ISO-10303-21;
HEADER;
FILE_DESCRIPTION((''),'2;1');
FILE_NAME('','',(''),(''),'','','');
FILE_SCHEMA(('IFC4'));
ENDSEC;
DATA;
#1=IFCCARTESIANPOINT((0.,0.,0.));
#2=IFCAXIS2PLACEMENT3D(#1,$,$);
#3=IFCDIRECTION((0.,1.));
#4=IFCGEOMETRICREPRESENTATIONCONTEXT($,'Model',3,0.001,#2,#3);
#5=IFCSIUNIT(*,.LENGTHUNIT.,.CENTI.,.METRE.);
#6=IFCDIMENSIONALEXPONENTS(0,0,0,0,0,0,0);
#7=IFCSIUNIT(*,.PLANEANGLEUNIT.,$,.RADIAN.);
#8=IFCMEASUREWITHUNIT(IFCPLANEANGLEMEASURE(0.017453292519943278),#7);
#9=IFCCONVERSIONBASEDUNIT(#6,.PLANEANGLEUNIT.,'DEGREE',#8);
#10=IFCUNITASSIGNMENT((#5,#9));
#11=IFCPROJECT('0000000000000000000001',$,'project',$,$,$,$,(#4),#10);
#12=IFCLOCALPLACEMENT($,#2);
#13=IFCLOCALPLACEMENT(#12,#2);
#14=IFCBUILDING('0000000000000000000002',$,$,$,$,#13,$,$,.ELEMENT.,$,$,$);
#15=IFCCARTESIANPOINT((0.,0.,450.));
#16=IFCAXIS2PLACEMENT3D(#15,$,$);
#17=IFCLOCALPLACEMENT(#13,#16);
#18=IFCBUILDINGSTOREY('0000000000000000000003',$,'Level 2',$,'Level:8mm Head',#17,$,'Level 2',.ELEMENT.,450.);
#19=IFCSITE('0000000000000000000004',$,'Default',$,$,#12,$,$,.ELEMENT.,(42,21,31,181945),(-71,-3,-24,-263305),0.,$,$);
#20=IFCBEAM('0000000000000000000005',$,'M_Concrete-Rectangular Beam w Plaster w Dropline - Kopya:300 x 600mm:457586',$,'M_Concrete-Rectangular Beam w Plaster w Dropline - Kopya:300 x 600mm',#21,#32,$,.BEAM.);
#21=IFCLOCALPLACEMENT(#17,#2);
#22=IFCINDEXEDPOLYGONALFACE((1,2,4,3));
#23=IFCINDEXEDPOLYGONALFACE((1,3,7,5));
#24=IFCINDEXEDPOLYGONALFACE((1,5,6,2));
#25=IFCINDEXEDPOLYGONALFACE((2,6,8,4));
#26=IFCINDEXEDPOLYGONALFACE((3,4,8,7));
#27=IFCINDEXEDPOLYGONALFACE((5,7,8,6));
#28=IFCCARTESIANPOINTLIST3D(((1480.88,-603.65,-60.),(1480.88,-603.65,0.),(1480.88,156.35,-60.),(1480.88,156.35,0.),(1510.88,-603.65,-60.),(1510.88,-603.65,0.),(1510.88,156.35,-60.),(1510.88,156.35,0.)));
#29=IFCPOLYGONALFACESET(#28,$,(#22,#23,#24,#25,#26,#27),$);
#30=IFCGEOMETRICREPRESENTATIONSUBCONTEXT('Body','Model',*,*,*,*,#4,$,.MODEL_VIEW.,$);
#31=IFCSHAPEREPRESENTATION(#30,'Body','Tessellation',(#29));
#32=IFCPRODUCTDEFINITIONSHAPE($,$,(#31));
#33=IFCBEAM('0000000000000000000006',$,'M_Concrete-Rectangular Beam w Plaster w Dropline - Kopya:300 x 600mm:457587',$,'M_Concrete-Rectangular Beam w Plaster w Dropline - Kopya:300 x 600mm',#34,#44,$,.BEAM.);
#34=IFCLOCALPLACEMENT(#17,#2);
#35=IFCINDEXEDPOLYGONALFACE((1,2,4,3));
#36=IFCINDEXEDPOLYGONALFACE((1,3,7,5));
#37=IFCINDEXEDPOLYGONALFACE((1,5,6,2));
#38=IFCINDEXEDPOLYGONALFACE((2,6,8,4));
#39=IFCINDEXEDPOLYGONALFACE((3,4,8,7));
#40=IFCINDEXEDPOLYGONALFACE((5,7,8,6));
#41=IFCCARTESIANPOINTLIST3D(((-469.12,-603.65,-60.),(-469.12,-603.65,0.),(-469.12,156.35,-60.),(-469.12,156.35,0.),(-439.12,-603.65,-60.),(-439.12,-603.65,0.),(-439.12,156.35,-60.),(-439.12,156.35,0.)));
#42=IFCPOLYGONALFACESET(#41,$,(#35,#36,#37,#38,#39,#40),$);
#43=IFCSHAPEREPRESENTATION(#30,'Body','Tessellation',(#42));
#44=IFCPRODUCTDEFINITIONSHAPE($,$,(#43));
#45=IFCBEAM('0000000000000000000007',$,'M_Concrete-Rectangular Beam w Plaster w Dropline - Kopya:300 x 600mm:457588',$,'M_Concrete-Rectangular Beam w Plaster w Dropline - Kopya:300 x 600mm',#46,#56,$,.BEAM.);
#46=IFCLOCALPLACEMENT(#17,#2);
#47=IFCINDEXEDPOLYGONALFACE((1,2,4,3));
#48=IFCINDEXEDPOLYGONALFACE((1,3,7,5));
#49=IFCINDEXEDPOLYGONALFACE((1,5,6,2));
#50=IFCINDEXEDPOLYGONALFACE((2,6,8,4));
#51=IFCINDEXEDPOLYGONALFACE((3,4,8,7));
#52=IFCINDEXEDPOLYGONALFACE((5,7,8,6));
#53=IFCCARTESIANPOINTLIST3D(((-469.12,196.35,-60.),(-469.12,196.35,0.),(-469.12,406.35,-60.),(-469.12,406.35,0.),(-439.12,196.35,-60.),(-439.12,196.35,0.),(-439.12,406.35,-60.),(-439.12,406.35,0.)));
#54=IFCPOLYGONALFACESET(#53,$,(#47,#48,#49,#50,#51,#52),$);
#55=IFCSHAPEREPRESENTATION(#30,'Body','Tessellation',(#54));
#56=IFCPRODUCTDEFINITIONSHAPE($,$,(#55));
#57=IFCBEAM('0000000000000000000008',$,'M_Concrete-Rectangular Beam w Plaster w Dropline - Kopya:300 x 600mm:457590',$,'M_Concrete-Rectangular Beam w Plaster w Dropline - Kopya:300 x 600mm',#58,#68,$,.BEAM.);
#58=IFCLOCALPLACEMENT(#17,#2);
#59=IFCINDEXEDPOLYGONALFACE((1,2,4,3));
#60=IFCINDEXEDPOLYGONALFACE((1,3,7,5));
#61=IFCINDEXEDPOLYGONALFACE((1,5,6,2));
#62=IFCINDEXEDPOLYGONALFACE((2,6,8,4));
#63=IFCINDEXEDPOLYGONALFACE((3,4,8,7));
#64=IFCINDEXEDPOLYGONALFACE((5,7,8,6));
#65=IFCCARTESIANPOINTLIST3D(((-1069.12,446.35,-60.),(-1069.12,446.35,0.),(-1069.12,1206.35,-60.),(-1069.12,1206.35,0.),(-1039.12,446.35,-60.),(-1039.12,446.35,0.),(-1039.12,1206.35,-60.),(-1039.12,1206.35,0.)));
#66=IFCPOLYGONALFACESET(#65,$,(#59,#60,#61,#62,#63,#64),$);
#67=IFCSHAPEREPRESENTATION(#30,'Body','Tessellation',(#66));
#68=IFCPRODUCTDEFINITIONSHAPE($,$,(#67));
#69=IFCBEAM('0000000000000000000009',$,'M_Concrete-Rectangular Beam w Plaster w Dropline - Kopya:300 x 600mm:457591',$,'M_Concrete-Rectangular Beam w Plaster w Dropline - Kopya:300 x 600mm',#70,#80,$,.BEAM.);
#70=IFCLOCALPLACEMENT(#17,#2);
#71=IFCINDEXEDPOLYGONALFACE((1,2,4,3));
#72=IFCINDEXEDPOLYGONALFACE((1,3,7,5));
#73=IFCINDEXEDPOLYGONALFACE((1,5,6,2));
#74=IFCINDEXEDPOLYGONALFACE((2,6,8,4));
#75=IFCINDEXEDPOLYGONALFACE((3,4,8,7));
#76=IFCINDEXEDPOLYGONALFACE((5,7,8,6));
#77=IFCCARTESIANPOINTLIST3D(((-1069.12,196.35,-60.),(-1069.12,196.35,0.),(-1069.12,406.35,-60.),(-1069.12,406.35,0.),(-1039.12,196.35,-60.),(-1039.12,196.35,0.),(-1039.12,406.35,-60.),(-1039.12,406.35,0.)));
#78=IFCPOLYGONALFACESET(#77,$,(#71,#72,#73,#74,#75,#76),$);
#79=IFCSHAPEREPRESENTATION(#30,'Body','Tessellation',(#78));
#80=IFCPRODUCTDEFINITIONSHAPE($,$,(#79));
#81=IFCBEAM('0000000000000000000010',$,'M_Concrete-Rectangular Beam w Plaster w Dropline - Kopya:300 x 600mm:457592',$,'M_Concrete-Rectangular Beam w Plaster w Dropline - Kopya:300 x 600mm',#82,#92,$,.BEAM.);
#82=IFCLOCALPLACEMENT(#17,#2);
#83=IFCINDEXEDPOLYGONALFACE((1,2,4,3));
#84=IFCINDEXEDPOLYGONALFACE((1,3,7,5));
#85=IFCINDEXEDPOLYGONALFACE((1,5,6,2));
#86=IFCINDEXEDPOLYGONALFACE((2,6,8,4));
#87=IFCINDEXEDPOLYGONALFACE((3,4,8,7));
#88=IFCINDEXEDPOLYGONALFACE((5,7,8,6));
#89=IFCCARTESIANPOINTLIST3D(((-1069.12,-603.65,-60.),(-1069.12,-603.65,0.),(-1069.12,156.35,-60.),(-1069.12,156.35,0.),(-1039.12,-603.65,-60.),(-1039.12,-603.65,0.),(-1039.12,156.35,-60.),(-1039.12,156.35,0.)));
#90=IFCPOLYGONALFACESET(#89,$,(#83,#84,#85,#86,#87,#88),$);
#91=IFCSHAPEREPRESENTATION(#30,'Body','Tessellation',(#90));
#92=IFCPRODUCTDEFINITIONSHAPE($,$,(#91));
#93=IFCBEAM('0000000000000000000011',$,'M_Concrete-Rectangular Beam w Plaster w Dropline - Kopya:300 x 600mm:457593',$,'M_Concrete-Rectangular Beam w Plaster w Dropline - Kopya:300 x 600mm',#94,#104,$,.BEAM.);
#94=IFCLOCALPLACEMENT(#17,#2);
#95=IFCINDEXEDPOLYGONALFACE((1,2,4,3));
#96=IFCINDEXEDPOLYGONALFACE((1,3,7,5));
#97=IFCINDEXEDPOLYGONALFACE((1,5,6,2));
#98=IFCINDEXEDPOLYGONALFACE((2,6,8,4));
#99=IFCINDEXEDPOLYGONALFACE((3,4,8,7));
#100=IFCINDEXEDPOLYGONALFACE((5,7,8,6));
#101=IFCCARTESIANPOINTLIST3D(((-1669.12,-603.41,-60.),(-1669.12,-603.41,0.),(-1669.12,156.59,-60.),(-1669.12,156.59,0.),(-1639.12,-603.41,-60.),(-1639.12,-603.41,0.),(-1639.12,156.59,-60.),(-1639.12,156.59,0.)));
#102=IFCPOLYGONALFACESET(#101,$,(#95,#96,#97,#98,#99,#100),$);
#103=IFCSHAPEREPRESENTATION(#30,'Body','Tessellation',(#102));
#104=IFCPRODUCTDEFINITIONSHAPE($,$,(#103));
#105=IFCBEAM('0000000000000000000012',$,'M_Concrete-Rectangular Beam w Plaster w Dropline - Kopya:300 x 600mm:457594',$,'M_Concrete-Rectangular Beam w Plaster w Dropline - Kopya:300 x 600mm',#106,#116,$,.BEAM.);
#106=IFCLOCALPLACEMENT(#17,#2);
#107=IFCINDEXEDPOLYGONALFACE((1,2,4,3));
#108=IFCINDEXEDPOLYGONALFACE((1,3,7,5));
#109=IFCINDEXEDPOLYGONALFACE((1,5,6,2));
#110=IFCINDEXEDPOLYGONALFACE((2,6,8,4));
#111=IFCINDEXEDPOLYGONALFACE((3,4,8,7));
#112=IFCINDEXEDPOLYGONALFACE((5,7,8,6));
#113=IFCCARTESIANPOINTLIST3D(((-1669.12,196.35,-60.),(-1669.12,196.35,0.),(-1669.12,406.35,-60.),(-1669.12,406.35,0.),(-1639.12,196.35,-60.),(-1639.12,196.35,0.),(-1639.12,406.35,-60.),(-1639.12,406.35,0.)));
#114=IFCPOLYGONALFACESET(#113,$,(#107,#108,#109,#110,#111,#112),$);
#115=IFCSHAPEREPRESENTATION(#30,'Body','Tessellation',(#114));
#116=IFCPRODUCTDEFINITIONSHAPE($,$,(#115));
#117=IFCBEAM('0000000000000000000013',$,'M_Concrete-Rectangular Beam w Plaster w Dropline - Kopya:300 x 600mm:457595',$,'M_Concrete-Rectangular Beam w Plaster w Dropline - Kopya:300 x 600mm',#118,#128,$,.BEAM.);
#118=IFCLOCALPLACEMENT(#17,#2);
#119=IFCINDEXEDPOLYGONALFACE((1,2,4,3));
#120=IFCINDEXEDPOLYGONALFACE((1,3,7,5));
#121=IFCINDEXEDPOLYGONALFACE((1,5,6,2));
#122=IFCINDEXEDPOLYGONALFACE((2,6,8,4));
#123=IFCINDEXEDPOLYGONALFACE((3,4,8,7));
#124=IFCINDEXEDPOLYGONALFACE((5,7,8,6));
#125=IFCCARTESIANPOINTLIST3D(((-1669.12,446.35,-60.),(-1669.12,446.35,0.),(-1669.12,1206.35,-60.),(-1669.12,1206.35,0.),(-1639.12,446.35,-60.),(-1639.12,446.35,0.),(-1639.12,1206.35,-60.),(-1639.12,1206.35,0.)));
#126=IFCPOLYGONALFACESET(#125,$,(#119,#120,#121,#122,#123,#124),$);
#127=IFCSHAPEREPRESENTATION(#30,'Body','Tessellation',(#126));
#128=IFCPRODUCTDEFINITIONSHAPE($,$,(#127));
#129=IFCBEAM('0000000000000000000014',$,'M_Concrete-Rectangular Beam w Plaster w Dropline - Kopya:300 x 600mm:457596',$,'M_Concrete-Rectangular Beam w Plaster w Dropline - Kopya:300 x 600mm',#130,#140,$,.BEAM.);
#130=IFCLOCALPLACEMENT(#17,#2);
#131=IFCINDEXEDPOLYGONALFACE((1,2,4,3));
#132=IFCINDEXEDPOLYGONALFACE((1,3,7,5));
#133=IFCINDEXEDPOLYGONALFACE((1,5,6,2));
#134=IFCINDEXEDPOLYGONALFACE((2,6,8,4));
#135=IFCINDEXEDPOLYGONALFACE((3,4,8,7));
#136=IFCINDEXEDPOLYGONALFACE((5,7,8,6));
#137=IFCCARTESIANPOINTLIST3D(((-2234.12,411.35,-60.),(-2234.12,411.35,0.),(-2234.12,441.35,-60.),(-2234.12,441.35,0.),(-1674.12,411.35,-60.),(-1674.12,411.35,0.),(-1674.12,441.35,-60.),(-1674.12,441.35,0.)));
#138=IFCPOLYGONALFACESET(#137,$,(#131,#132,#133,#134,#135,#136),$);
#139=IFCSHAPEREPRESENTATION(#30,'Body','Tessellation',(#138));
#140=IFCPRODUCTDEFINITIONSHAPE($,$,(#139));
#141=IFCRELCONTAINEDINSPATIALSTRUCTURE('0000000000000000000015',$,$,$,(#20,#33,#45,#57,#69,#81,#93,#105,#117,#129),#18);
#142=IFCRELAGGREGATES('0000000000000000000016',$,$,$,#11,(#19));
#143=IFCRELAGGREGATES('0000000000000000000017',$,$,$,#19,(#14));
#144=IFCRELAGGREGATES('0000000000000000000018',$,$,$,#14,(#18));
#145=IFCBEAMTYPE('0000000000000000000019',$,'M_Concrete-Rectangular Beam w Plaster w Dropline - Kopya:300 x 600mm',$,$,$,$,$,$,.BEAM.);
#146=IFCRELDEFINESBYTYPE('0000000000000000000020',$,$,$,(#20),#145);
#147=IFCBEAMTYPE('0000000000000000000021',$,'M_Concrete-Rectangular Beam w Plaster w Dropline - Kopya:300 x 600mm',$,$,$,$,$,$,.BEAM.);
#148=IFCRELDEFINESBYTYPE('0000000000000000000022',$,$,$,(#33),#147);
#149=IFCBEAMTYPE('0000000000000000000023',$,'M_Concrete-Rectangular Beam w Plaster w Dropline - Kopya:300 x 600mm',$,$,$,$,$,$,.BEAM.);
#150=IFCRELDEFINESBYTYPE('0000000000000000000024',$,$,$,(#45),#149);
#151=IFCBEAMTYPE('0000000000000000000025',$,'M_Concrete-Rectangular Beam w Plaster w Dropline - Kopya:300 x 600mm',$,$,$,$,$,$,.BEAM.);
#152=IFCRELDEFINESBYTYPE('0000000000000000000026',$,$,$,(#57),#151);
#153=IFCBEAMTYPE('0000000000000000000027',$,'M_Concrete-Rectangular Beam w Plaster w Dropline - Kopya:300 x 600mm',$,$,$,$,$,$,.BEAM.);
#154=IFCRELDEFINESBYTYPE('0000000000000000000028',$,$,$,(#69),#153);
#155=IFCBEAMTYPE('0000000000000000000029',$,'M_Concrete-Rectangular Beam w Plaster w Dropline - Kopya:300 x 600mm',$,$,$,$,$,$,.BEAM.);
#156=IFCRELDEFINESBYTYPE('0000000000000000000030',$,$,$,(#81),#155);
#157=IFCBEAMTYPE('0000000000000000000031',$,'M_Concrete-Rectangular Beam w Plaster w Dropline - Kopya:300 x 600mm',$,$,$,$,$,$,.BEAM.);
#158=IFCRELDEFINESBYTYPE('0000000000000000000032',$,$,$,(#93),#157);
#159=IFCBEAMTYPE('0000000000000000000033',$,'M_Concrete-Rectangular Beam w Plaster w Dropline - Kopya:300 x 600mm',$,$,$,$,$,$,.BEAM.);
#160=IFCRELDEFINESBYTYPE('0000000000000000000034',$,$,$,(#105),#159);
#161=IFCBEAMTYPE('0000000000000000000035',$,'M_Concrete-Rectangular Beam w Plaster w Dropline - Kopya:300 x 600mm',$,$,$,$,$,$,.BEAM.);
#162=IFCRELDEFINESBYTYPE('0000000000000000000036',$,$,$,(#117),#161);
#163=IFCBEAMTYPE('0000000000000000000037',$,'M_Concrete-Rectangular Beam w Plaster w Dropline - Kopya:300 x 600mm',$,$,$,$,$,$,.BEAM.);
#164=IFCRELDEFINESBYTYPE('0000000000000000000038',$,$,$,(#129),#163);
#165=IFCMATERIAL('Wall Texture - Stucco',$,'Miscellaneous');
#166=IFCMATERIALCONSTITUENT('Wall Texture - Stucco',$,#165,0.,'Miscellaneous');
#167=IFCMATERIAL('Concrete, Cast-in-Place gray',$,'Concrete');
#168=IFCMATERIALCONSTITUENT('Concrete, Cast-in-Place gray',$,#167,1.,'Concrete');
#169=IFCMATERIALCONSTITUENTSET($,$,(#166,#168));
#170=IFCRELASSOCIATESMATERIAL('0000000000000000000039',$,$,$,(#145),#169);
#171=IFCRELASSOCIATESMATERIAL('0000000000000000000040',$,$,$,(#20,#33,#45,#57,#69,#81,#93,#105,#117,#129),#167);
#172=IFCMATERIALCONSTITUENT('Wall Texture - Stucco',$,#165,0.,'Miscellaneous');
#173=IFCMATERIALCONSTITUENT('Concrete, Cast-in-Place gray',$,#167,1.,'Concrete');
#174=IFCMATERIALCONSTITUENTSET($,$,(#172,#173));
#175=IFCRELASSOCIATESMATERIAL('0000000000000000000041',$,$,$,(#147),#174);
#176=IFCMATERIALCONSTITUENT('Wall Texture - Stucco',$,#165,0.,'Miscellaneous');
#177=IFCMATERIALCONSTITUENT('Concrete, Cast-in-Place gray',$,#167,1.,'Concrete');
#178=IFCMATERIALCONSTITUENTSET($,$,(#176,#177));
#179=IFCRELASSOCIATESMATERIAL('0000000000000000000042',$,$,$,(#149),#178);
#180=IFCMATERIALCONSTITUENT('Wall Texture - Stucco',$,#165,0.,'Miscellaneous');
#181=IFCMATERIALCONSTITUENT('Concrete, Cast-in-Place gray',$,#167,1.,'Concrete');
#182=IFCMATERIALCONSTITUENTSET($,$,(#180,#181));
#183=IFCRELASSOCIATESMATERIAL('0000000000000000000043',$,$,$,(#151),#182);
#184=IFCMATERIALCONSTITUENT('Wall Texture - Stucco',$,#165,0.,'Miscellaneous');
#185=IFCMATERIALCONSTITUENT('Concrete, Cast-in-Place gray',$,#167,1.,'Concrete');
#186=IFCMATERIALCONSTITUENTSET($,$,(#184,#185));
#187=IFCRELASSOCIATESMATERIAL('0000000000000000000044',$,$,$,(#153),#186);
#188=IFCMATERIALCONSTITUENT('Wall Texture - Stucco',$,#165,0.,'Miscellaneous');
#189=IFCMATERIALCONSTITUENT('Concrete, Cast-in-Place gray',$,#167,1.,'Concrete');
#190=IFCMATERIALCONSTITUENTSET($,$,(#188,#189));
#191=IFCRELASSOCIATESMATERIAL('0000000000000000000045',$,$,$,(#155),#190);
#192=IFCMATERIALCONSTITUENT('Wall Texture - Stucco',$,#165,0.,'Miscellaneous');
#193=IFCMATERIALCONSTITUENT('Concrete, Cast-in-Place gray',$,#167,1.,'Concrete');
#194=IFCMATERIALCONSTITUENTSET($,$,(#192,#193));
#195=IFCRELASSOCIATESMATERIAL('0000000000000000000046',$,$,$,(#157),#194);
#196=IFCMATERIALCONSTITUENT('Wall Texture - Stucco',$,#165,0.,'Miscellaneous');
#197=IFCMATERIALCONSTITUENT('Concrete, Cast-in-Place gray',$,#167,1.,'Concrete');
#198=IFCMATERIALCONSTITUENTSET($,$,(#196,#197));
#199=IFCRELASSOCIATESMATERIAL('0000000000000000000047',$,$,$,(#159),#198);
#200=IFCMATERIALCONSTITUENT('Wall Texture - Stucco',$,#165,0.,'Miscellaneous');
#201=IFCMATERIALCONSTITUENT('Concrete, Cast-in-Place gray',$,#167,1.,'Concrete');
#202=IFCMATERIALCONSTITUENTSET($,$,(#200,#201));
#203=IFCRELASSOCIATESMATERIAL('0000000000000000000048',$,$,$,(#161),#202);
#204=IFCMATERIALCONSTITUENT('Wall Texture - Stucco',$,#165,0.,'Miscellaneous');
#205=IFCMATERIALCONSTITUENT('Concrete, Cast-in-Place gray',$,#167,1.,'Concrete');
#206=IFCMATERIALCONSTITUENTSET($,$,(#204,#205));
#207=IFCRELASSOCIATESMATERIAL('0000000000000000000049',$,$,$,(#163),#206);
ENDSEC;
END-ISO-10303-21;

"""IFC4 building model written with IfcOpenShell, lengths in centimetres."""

from ifc_helpers import new_model, entity, si_unit, converted_unit, direction, frame, origin, place, context, subcontext, project, spatial, indexed_curve, outline, extrude, source, transform, mapped, material, constituent, constituent_set, type_object, type_shapes, element, save


model = new_model("IFC4")

# Units and contexts
model_context = context("Model", 3, precision=0.001, world=origin(), true_north=direction((0.0, 1.0)))
body_context = subcontext(model_context, "Body", "Model", "MODEL_VIEW")
ifc_project = project(units=[si_unit("LENGTHUNIT", "METRE", prefix="CENTI"), converted_unit("PLANEANGLEUNIT", "DEGREE", entity("IfcPlaneAngleMeasure", 0.017453292519943278), si_unit("PLANEANGLEUNIT", "RADIAN"), dimensions=[0, 0, 0, 0, 0, 0, 0])], contexts=[model_context])

# Site, building, storey
site_placement = place(None, origin())
site = spatial("IfcSite", under=ifc_project, at=site_placement, Name="Default", CompositionType="ELEMENT", RefLatitude=(42, 21, 31, 181945), RefLongitude=(-71, -3, -24, -263305), RefElevation=0.0)
building_placement = place(site_placement, origin())
building = spatial("IfcBuilding", under=site, at=building_placement, CompositionType="ELEMENT")
storey_placement = place(building_placement, frame((0.0, 0.0, 450.0)))
storey = spatial("IfcBuildingStorey", under=building, at=storey_placement, Name="Level 2", ObjectType="Level:8mm Head", LongName="Level 2", CompositionType="ELEMENT", Elevation=450.0)

# Beams
ifc_material_1 = material(Name="Concrete, Cast-in-Place gray", Category="Concrete")
ifc_material_2 = material(Name="Wall Texture - Stucco", Category="Miscellaneous")
ifc_constituent_1 = constituent(ifc_material_2, Name="Wall Texture - Stucco", Category="Miscellaneous", fraction=0.0)
ifc_constituent_2 = constituent(ifc_material_1, Name="Concrete, Cast-in-Place gray", Category="Concrete", fraction=1.0)
ifc_constituent_set_1 = constituent_set(constituents=[ifc_constituent_1, ifc_constituent_2])
beam_type_1 = type_object("IfcBeamType", Name="M_Concrete-Rectangular Beam w Plaster w Dropline - Kopya:300 x 600mm", PredefinedType="BEAM", material=ifc_constituent_set_1)
shared_shape_1 = source(origin(), body_context, "Body", "SweptSolid", [
    extrude(outline(indexed_curve([(-15.0, -30.0), (15.0, -30.0), (15.0, 30.0), (-15.0, 30.0), (-15.0, -30.0)], self_intersect=False)), frame((1495.88, 156.35, 420.0), z_axis=(0.0, -1.0, 0.0), x_axis=(-1.0, 0.0, 0.0)), (0.0, 0.0, 1.0), 760.0),
])
type_shapes(beam_type_1, [shared_shape_1])
beam_1_placement = place(storey_placement, frame((0.0, 0.0, -450.0)))
element("IfcBeam", 1, at=beam_1_placement, inside=storey, type_object=beam_type_1, material=ifc_material_1, Name="M_Concrete-Rectangular Beam w Plaster w Dropline - Kopya:300 x 600mm:457586", ObjectType="M_Concrete-Rectangular Beam w Plaster w Dropline - Kopya:300 x 600mm", PredefinedType="BEAM", context=body_context, shape_type="MappedRepresentation", body=[
    mapped(shared_shape_1, transform((0.0, 0.0, 0.0), scale=1.0)),
])
ifc_constituent_3 = constituent(ifc_material_2, Name="Wall Texture - Stucco", Category="Miscellaneous", fraction=0.0)
ifc_constituent_4 = constituent(ifc_material_1, Name="Concrete, Cast-in-Place gray", Category="Concrete", fraction=1.0)
ifc_constituent_set_2 = constituent_set(constituents=[ifc_constituent_3, ifc_constituent_4])
beam_type_2 = type_object("IfcBeamType", Name="M_Concrete-Rectangular Beam w Plaster w Dropline - Kopya:300 x 600mm", PredefinedType="BEAM", material=ifc_constituent_set_2)
shared_shape_2 = source(origin(), body_context, "Body", "SweptSolid", [
    extrude(outline(indexed_curve([(-15.0, -30.0), (15.0, -30.0), (15.0, 30.0), (-15.0, 30.0), (-15.0, -30.0)], self_intersect=False)), frame((-454.12, -603.65, 420.0), z_axis=(0.0, 1.0, 0.0), x_axis=(-1.0, 0.0, 0.0)), (0.0, 0.0, 1.0), 760.0),
])
type_shapes(beam_type_2, [shared_shape_2])
beam_2_placement = place(storey_placement, frame((0.0, 0.0, -450.0)))
element("IfcBeam", 2, at=beam_2_placement, inside=storey, type_object=beam_type_2, material=ifc_material_1, Name="M_Concrete-Rectangular Beam w Plaster w Dropline - Kopya:300 x 600mm:457587", ObjectType="M_Concrete-Rectangular Beam w Plaster w Dropline - Kopya:300 x 600mm", PredefinedType="BEAM", context=body_context, shape_type="MappedRepresentation", body=[
    mapped(shared_shape_2, transform((0.0, 0.0, 0.0), scale=1.0)),
])
ifc_constituent_5 = constituent(ifc_material_2, Name="Wall Texture - Stucco", Category="Miscellaneous", fraction=0.0)
ifc_constituent_6 = constituent(ifc_material_1, Name="Concrete, Cast-in-Place gray", Category="Concrete", fraction=1.0)
ifc_constituent_set_3 = constituent_set(constituents=[ifc_constituent_5, ifc_constituent_6])
beam_type_3 = type_object("IfcBeamType", Name="M_Concrete-Rectangular Beam w Plaster w Dropline - Kopya:300 x 600mm", PredefinedType="BEAM", material=ifc_constituent_set_3)
shared_shape_3 = source(origin(), body_context, "Body", "SweptSolid", [
    extrude(outline(indexed_curve([(-15.0, -30.0), (15.0, -30.0), (15.0, 30.0), (-15.0, 30.0), (-15.0, -30.0)], self_intersect=False)), frame((-454.12, 196.35, 420.0), z_axis=(0.0, 1.0, 0.0), x_axis=(-1.0, 0.0, 0.0)), (0.0, 0.0, 1.0), 210.0),
])
type_shapes(beam_type_3, [shared_shape_3])
beam_3_placement = place(storey_placement, frame((0.0, 0.0, -450.0)))
element("IfcBeam", 3, at=beam_3_placement, inside=storey, type_object=beam_type_3, material=ifc_material_1, Name="M_Concrete-Rectangular Beam w Plaster w Dropline - Kopya:300 x 600mm:457588", ObjectType="M_Concrete-Rectangular Beam w Plaster w Dropline - Kopya:300 x 600mm", PredefinedType="BEAM", context=body_context, shape_type="MappedRepresentation", body=[
    mapped(shared_shape_3, transform((0.0, 0.0, 0.0), scale=1.0)),
])
ifc_constituent_7 = constituent(ifc_material_2, Name="Wall Texture - Stucco", Category="Miscellaneous", fraction=0.0)
ifc_constituent_8 = constituent(ifc_material_1, Name="Concrete, Cast-in-Place gray", Category="Concrete", fraction=1.0)
ifc_constituent_set_4 = constituent_set(constituents=[ifc_constituent_7, ifc_constituent_8])
beam_type_4 = type_object("IfcBeamType", Name="M_Concrete-Rectangular Beam w Plaster w Dropline - Kopya:300 x 600mm", PredefinedType="BEAM", material=ifc_constituent_set_4)
shared_shape_4 = source(origin(), body_context, "Body", "SweptSolid", [
    extrude(outline(indexed_curve([(-15.0, -30.0), (15.0, -30.0), (15.0, 30.0), (-15.0, 30.0), (-15.0, -30.0)], self_intersect=False)), frame((-1054.12, 1206.35, 420.0), z_axis=(0.0, -1.0, 0.0), x_axis=(-1.0, 0.0, 0.0)), (0.0, 0.0, 1.0), 760.0),
])
type_shapes(beam_type_4, [shared_shape_4])
beam_4_placement = place(storey_placement, frame((0.0, 0.0, -450.0)))
element("IfcBeam", 4, at=beam_4_placement, inside=storey, type_object=beam_type_4, material=ifc_material_1, Name="M_Concrete-Rectangular Beam w Plaster w Dropline - Kopya:300 x 600mm:457590", ObjectType="M_Concrete-Rectangular Beam w Plaster w Dropline - Kopya:300 x 600mm", PredefinedType="BEAM", context=body_context, shape_type="MappedRepresentation", body=[
    mapped(shared_shape_4, transform((0.0, 0.0, 0.0), scale=1.0)),
])
ifc_constituent_9 = constituent(ifc_material_2, Name="Wall Texture - Stucco", Category="Miscellaneous", fraction=0.0)
ifc_constituent_10 = constituent(ifc_material_1, Name="Concrete, Cast-in-Place gray", Category="Concrete", fraction=1.0)
ifc_constituent_set_5 = constituent_set(constituents=[ifc_constituent_9, ifc_constituent_10])
beam_type_5 = type_object("IfcBeamType", Name="M_Concrete-Rectangular Beam w Plaster w Dropline - Kopya:300 x 600mm", PredefinedType="BEAM", material=ifc_constituent_set_5)
shared_shape_5 = source(origin(), body_context, "Body", "SweptSolid", [
    extrude(outline(indexed_curve([(-15.0, -30.0), (15.0, -30.0), (15.0, 30.0), (-15.0, 30.0), (-15.0, -30.0)], self_intersect=False)), frame((-1054.12, 406.35, 420.0), z_axis=(0.0, -1.0, 0.0), x_axis=(-1.0, 0.0, 0.0)), (0.0, 0.0, 1.0), 210.0),
])
type_shapes(beam_type_5, [shared_shape_5])
beam_5_placement = place(storey_placement, frame((0.0, 0.0, -450.0)))
element("IfcBeam", 5, at=beam_5_placement, inside=storey, type_object=beam_type_5, material=ifc_material_1, Name="M_Concrete-Rectangular Beam w Plaster w Dropline - Kopya:300 x 600mm:457591", ObjectType="M_Concrete-Rectangular Beam w Plaster w Dropline - Kopya:300 x 600mm", PredefinedType="BEAM", context=body_context, shape_type="MappedRepresentation", body=[
    mapped(shared_shape_5, transform((0.0, 0.0, 0.0), scale=1.0)),
])
ifc_constituent_11 = constituent(ifc_material_2, Name="Wall Texture - Stucco", Category="Miscellaneous", fraction=0.0)
ifc_constituent_12 = constituent(ifc_material_1, Name="Concrete, Cast-in-Place gray", Category="Concrete", fraction=1.0)
ifc_constituent_set_6 = constituent_set(constituents=[ifc_constituent_11, ifc_constituent_12])
beam_type_6 = type_object("IfcBeamType", Name="M_Concrete-Rectangular Beam w Plaster w Dropline - Kopya:300 x 600mm", PredefinedType="BEAM", material=ifc_constituent_set_6)
shared_shape_6 = source(origin(), body_context, "Body", "SweptSolid", [
    extrude(outline(indexed_curve([(-15.0, -30.0), (15.0, -30.0), (15.0, 30.0), (-15.0, 30.0), (-15.0, -30.0)], self_intersect=False)), frame((-1054.12, 156.35, 420.0), z_axis=(0.0, -1.0, 0.0), x_axis=(-1.0, 0.0, 0.0)), (0.0, 0.0, 1.0), 760.0),
])
type_shapes(beam_type_6, [shared_shape_6])
beam_6_placement = place(storey_placement, frame((0.0, 0.0, -450.0)))
element("IfcBeam", 6, at=beam_6_placement, inside=storey, type_object=beam_type_6, material=ifc_material_1, Name="M_Concrete-Rectangular Beam w Plaster w Dropline - Kopya:300 x 600mm:457592", ObjectType="M_Concrete-Rectangular Beam w Plaster w Dropline - Kopya:300 x 600mm", PredefinedType="BEAM", context=body_context, shape_type="MappedRepresentation", body=[
    mapped(shared_shape_6, transform((0.0, 0.0, 0.0), scale=1.0)),
])
ifc_constituent_13 = constituent(ifc_material_2, Name="Wall Texture - Stucco", Category="Miscellaneous", fraction=0.0)
ifc_constituent_14 = constituent(ifc_material_1, Name="Concrete, Cast-in-Place gray", Category="Concrete", fraction=1.0)
ifc_constituent_set_7 = constituent_set(constituents=[ifc_constituent_13, ifc_constituent_14])
beam_type_7 = type_object("IfcBeamType", Name="M_Concrete-Rectangular Beam w Plaster w Dropline - Kopya:300 x 600mm", PredefinedType="BEAM", material=ifc_constituent_set_7)
shared_shape_7 = source(origin(), body_context, "Body", "SweptSolid", [
    extrude(outline(indexed_curve([(-15.0, -30.0), (15.0, -30.0), (15.0, 30.0), (-15.0, 30.0), (-15.0, -30.0)], self_intersect=False)), frame((-1654.12, -603.41, 420.0), z_axis=(0.0, 1.0, 0.0), x_axis=(-1.0, 0.0, 0.0)), (0.0, 0.0, 1.0), 760.0),
])
type_shapes(beam_type_7, [shared_shape_7])
beam_7_placement = place(storey_placement, frame((0.0, 0.0, -450.0)))
element("IfcBeam", 7, at=beam_7_placement, inside=storey, type_object=beam_type_7, material=ifc_material_1, Name="M_Concrete-Rectangular Beam w Plaster w Dropline - Kopya:300 x 600mm:457593", ObjectType="M_Concrete-Rectangular Beam w Plaster w Dropline - Kopya:300 x 600mm", PredefinedType="BEAM", context=body_context, shape_type="MappedRepresentation", body=[
    mapped(shared_shape_7, transform((0.0, 0.0, 0.0), scale=1.0)),
])
ifc_constituent_15 = constituent(ifc_material_2, Name="Wall Texture - Stucco", Category="Miscellaneous", fraction=0.0)
ifc_constituent_16 = constituent(ifc_material_1, Name="Concrete, Cast-in-Place gray", Category="Concrete", fraction=1.0)
ifc_constituent_set_8 = constituent_set(constituents=[ifc_constituent_15, ifc_constituent_16])
beam_type_8 = type_object("IfcBeamType", Name="M_Concrete-Rectangular Beam w Plaster w Dropline - Kopya:300 x 600mm", PredefinedType="BEAM", material=ifc_constituent_set_8)
shared_shape_8 = source(origin(), body_context, "Body", "SweptSolid", [
    extrude(outline(indexed_curve([(-15.0, -30.0), (15.0, -30.0), (15.0, 30.0), (-15.0, 30.0), (-15.0, -30.0)], self_intersect=False)), frame((-1654.12, 196.35, 420.0), z_axis=(0.0, 1.0, 0.0), x_axis=(-1.0, 0.0, 0.0)), (0.0, 0.0, 1.0), 210.0),
])
type_shapes(beam_type_8, [shared_shape_8])
beam_8_placement = place(storey_placement, frame((0.0, 0.0, -450.0)))
element("IfcBeam", 8, at=beam_8_placement, inside=storey, type_object=beam_type_8, material=ifc_material_1, Name="M_Concrete-Rectangular Beam w Plaster w Dropline - Kopya:300 x 600mm:457594", ObjectType="M_Concrete-Rectangular Beam w Plaster w Dropline - Kopya:300 x 600mm", PredefinedType="BEAM", context=body_context, shape_type="MappedRepresentation", body=[
    mapped(shared_shape_8, transform((0.0, 0.0, 0.0), scale=1.0)),
])
ifc_constituent_17 = constituent(ifc_material_2, Name="Wall Texture - Stucco", Category="Miscellaneous", fraction=0.0)
ifc_constituent_18 = constituent(ifc_material_1, Name="Concrete, Cast-in-Place gray", Category="Concrete", fraction=1.0)
ifc_constituent_set_9 = constituent_set(constituents=[ifc_constituent_17, ifc_constituent_18])
beam_type_9 = type_object("IfcBeamType", Name="M_Concrete-Rectangular Beam w Plaster w Dropline - Kopya:300 x 600mm", PredefinedType="BEAM", material=ifc_constituent_set_9)
shared_shape_9 = source(origin(), body_context, "Body", "SweptSolid", [
    extrude(outline(indexed_curve([(-15.0, -30.0), (15.0, -30.0), (15.0, 30.0), (-15.0, 30.0), (-15.0, -30.0)], self_intersect=False)), frame((-1654.12, 446.35, 420.0), z_axis=(0.0, 1.0, 0.0), x_axis=(-1.0, 0.0, 0.0)), (0.0, 0.0, 1.0), 760.0),
])
type_shapes(beam_type_9, [shared_shape_9])
beam_9_placement = place(storey_placement, frame((0.0, 0.0, -450.0)))
element("IfcBeam", 9, at=beam_9_placement, inside=storey, type_object=beam_type_9, material=ifc_material_1, Name="M_Concrete-Rectangular Beam w Plaster w Dropline - Kopya:300 x 600mm:457595", ObjectType="M_Concrete-Rectangular Beam w Plaster w Dropline - Kopya:300 x 600mm", PredefinedType="BEAM", context=body_context, shape_type="MappedRepresentation", body=[
    mapped(shared_shape_9, transform((0.0, 0.0, 0.0), scale=1.0)),
])
ifc_constituent_19 = constituent(ifc_material_2, Name="Wall Texture - Stucco", Category="Miscellaneous", fraction=0.0)
ifc_constituent_20 = constituent(ifc_material_1, Name="Concrete, Cast-in-Place gray", Category="Concrete", fraction=1.0)
ifc_constituent_set_10 = constituent_set(constituents=[ifc_constituent_19, ifc_constituent_20])
beam_type_10 = type_object("IfcBeamType", Name="M_Concrete-Rectangular Beam w Plaster w Dropline - Kopya:300 x 600mm", PredefinedType="BEAM", material=ifc_constituent_set_10)
shared_shape_10 = source(origin(), body_context, "Body", "SweptSolid", [
    extrude(outline(indexed_curve([(-30.0, -15.0), (30.0, -15.0), (30.0, 15.0), (-30.0, 15.0), (-30.0, -15.0)], self_intersect=False)), frame((-2234.12, 426.35, 420.0), z_axis=(1.0, 0.0, 0.0), x_axis=(0.0, 0.0, -1.0)), (0.0, 0.0, 1.0), 560.0),
])
type_shapes(beam_type_10, [shared_shape_10])
beam_10_placement = place(storey_placement, frame((0.0, 0.0, -450.0)))
element("IfcBeam", 10, at=beam_10_placement, inside=storey, type_object=beam_type_10, material=ifc_material_1, Name="M_Concrete-Rectangular Beam w Plaster w Dropline - Kopya:300 x 600mm:457596", ObjectType="M_Concrete-Rectangular Beam w Plaster w Dropline - Kopya:300 x 600mm", PredefinedType="BEAM", context=body_context, shape_type="MappedRepresentation", body=[
    mapped(shared_shape_10, transform((0.0, 0.0, 0.0), scale=1.0)),
])

save(model, "model.ifc")
